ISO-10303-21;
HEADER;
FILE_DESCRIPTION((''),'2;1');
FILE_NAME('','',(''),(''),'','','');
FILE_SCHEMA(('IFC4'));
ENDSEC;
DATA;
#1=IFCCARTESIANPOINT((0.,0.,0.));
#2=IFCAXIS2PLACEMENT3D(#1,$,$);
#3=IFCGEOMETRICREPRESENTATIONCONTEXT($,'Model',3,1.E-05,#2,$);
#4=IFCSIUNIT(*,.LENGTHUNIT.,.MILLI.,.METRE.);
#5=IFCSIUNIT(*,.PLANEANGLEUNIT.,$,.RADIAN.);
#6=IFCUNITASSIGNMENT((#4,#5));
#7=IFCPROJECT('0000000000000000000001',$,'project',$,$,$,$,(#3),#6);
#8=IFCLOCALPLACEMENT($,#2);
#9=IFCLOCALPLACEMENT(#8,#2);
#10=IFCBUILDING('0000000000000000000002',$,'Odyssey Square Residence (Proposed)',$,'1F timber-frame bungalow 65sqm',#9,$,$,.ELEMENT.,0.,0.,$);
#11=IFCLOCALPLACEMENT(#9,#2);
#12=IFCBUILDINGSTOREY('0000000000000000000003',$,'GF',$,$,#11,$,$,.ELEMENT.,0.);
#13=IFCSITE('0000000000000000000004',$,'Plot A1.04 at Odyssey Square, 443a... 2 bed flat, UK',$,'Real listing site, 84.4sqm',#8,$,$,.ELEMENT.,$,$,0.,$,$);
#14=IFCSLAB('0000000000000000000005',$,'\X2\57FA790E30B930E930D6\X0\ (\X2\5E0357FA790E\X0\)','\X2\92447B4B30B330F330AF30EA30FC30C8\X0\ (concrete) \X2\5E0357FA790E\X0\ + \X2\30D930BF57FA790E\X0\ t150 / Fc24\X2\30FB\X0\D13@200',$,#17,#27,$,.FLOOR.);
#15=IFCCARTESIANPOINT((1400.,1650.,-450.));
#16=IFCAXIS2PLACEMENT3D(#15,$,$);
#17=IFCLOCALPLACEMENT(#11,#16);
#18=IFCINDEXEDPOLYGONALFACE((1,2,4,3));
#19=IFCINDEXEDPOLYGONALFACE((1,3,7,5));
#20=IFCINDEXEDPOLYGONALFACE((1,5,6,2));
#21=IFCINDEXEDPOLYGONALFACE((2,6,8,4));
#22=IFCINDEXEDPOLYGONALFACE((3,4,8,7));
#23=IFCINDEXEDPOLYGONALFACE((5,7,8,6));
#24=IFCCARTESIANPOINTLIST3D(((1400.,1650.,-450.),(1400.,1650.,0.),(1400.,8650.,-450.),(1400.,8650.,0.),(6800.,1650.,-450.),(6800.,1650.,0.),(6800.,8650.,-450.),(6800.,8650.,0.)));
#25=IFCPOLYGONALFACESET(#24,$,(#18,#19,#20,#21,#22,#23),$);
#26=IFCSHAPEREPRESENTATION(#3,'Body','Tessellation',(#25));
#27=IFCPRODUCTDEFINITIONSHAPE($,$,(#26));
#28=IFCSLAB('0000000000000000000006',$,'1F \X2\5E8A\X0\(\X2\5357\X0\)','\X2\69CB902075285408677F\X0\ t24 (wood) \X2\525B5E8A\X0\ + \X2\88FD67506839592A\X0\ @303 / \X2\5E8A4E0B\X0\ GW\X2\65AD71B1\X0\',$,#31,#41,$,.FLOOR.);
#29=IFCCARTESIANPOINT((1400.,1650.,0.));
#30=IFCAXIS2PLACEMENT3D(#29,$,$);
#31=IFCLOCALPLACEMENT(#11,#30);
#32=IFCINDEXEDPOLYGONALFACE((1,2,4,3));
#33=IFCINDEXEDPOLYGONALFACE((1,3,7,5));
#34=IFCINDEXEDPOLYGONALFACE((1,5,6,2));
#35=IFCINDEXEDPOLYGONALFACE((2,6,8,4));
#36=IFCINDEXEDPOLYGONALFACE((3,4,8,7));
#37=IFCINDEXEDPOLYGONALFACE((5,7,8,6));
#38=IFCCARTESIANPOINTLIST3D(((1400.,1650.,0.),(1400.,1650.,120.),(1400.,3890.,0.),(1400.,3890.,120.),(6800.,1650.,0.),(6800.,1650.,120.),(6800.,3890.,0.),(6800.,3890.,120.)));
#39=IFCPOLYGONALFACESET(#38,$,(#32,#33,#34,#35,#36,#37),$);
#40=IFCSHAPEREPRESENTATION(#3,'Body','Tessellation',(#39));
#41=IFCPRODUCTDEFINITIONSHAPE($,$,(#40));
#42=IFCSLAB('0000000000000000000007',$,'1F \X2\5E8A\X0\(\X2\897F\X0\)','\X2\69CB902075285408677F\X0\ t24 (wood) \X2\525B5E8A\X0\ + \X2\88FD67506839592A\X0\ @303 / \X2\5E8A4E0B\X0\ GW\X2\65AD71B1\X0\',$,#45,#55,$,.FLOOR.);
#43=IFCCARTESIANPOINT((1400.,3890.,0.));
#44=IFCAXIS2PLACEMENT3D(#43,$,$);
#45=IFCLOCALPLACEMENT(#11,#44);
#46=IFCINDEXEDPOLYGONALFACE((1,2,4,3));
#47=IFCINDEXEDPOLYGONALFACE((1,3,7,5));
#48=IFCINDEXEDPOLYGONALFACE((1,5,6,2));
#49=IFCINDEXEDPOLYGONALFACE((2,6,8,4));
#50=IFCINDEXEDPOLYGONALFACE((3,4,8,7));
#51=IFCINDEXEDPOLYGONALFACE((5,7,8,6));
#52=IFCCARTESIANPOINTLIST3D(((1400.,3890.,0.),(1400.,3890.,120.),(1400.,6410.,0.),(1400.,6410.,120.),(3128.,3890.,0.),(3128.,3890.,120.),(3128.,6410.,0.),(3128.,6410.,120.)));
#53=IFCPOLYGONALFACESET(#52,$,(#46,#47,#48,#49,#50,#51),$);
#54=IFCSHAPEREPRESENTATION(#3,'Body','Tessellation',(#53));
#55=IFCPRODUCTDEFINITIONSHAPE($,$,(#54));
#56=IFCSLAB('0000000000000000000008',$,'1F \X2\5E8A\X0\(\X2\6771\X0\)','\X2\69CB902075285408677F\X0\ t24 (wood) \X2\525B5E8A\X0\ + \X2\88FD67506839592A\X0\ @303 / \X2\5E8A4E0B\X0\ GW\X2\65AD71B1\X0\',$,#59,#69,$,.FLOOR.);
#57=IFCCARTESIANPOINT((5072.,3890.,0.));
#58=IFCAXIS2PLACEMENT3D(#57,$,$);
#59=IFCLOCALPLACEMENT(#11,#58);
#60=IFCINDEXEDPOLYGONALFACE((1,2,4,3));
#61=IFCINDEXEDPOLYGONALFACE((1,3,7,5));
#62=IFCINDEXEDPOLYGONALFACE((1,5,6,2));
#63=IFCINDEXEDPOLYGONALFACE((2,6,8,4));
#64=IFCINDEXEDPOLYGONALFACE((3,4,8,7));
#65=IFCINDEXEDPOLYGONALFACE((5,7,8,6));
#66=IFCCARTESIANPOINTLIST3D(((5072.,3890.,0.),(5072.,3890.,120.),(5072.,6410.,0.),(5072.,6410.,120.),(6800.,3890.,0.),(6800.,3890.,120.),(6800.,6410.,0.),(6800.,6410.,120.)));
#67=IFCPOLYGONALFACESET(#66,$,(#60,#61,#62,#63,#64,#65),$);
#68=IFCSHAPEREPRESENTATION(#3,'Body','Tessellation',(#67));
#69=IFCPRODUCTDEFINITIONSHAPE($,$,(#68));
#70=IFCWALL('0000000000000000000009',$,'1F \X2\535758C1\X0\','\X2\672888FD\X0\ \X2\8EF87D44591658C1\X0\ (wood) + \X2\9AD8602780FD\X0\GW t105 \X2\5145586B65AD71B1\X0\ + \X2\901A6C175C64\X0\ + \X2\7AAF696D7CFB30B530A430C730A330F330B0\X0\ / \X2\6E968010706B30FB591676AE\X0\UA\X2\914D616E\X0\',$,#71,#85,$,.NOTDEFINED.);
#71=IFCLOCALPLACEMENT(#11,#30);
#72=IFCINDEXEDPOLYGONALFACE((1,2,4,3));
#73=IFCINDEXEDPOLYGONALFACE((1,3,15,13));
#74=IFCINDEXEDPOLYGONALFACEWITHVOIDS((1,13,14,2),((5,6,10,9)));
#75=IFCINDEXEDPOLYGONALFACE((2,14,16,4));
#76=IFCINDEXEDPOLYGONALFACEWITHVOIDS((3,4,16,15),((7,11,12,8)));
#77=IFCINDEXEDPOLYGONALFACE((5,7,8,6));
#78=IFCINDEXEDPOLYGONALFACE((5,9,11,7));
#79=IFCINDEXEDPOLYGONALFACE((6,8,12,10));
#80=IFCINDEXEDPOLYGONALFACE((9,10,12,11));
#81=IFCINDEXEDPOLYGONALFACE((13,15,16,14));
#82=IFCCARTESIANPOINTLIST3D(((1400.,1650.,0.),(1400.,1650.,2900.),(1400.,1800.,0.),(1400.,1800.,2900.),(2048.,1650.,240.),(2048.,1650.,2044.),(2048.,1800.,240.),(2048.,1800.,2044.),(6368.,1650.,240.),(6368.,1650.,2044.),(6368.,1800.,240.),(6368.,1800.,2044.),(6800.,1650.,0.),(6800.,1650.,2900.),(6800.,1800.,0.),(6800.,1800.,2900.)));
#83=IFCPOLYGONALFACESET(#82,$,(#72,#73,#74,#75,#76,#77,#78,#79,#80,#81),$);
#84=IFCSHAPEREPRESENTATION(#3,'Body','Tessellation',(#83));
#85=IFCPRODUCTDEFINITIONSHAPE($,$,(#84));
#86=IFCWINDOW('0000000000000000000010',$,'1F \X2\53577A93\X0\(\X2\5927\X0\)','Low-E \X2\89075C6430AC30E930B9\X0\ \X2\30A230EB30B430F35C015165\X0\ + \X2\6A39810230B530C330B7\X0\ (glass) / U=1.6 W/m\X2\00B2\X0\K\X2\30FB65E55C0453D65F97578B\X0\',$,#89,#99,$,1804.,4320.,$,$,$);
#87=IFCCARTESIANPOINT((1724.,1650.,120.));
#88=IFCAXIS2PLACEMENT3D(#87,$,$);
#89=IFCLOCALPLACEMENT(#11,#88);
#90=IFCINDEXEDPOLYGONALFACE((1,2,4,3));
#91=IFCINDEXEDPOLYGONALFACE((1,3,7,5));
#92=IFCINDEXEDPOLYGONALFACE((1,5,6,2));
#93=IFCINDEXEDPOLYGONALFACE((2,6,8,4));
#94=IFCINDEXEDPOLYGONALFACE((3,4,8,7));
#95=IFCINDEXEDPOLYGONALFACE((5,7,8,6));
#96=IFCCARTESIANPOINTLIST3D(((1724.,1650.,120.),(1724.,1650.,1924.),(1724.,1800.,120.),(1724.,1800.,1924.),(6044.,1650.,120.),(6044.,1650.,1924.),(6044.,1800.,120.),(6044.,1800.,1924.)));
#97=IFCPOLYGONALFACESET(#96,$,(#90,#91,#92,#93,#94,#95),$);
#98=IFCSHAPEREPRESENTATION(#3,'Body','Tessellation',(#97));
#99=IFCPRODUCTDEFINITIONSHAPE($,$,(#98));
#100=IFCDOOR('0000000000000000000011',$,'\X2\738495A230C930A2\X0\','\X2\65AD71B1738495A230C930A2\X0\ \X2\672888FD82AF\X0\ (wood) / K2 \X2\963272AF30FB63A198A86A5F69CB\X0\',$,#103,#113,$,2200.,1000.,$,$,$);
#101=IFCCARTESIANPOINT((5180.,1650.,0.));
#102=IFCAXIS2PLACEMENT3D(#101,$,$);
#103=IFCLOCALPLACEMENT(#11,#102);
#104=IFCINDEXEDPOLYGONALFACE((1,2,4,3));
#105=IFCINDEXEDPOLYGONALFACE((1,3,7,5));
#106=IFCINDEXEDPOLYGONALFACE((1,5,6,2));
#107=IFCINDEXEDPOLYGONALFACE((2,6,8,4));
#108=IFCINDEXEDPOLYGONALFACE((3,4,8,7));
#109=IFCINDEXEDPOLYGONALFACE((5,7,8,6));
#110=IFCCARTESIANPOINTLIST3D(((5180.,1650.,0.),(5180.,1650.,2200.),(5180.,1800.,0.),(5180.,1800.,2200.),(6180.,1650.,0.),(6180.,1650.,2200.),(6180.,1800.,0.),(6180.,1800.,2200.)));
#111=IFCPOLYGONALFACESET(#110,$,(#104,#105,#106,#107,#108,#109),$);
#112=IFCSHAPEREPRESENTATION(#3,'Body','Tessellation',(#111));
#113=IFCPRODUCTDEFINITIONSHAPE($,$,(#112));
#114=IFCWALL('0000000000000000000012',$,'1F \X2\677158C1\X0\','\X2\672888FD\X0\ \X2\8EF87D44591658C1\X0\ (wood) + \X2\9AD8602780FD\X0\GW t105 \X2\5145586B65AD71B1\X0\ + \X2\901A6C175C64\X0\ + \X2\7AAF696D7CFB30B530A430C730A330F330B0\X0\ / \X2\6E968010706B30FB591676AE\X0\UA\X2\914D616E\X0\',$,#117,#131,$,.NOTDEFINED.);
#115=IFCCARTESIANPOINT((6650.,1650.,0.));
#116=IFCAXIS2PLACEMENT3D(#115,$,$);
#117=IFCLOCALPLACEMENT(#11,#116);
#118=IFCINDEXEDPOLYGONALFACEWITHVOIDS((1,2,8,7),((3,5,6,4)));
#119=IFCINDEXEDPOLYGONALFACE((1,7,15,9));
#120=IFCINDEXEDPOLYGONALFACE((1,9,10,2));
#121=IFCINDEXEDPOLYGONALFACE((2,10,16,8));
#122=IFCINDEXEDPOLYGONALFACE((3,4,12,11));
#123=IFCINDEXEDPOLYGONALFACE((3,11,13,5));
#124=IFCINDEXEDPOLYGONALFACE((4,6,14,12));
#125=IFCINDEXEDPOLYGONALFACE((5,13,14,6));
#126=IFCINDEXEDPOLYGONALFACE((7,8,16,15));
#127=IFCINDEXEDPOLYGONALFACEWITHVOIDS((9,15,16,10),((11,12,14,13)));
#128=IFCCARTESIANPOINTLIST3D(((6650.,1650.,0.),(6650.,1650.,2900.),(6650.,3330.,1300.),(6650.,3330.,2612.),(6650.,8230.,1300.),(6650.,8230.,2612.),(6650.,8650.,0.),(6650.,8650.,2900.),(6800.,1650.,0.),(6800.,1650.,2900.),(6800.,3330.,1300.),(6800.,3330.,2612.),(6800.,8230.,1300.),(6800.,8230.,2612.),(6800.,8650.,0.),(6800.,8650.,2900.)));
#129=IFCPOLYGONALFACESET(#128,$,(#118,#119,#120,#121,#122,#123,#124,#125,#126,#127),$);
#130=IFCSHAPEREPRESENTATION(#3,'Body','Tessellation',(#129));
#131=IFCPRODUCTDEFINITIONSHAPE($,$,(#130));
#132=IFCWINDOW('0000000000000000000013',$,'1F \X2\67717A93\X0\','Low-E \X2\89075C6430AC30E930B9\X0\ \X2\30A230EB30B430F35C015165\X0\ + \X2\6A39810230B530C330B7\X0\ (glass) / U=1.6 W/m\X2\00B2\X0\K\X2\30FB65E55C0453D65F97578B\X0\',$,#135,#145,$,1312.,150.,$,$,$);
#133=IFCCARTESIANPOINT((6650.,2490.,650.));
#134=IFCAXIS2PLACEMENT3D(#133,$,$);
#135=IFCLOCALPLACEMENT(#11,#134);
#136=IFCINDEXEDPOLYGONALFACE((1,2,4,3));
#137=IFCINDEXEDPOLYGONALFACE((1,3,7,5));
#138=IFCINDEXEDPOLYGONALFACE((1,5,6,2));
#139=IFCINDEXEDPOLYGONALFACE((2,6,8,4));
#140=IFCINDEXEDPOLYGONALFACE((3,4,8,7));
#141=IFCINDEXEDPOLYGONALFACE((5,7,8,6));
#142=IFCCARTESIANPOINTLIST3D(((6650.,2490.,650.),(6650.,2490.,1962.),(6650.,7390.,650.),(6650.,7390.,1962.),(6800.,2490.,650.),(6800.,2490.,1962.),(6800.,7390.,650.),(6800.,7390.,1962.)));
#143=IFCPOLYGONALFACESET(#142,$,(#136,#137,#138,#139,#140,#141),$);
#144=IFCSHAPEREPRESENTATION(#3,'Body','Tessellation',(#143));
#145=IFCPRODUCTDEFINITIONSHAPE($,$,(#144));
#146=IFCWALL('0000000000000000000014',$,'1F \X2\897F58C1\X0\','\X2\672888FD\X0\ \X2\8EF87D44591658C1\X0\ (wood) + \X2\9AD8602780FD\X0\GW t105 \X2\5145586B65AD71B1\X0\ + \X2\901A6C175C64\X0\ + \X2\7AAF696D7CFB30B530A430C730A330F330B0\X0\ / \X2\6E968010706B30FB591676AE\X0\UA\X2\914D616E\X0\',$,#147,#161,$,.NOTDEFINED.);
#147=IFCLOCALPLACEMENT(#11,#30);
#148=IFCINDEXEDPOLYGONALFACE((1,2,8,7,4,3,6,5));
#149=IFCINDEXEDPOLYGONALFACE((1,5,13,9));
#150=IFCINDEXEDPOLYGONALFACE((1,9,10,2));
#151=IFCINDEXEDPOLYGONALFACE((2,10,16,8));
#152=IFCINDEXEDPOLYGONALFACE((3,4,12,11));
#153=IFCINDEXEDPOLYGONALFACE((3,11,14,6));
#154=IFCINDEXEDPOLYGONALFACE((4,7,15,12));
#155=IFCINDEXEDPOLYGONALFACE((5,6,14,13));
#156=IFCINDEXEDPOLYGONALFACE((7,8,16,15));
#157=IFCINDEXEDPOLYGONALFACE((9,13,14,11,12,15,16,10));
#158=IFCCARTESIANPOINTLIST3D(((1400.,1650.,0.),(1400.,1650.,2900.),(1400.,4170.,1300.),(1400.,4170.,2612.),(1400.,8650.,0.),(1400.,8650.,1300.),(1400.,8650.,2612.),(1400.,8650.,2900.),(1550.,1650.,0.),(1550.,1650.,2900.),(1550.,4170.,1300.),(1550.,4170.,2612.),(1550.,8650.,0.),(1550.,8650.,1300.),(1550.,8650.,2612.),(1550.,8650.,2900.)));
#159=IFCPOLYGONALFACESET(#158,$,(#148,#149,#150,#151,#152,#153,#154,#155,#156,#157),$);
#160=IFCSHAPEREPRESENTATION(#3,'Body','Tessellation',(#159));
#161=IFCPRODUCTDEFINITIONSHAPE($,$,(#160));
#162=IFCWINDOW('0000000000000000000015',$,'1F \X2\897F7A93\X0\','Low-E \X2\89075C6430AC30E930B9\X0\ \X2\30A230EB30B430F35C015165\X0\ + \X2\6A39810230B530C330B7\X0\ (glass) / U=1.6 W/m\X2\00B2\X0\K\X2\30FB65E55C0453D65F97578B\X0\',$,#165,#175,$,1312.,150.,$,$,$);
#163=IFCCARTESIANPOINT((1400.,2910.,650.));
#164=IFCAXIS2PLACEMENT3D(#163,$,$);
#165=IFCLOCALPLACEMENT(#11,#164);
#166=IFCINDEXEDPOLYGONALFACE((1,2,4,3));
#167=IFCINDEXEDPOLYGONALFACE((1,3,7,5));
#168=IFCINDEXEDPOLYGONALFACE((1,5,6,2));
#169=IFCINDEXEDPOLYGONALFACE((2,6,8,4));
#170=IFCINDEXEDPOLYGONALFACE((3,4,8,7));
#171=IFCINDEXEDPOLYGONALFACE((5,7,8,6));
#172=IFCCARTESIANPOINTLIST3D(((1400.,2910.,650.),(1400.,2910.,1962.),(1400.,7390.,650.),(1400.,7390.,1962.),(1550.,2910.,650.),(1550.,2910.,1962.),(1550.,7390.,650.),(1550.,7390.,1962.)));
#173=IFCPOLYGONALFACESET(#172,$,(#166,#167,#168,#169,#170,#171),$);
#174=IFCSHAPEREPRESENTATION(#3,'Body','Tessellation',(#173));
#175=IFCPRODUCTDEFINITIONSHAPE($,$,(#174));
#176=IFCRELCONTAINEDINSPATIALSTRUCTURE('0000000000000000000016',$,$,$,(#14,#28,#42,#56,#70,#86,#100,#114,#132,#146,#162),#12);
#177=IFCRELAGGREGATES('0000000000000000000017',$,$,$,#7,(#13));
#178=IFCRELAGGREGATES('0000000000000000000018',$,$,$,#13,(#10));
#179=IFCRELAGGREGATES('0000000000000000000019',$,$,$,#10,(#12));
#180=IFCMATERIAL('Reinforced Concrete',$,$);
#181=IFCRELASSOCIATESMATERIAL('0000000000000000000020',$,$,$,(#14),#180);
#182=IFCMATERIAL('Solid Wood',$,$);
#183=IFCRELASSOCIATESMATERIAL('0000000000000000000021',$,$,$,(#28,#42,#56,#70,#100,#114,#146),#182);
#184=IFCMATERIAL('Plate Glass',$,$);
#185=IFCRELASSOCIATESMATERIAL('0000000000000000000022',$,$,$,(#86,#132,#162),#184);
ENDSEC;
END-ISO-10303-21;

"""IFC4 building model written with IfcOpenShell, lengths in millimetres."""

from ifc_helpers import new_model, si_unit, frame, frame_2d, origin, place, context, project, spatial, rectangle, extrude, material, element, fill, save


model = new_model("IFC4")

# Units and contexts
model_context = context("Model", 3, precision=1e-05, world=origin())
ifc_project = project(units=[si_unit("LENGTHUNIT", "METRE", prefix="MILLI"), si_unit("PLANEANGLEUNIT", "RADIAN")], contexts=[model_context])

# Site, building, storey
site_placement = place(None, origin())
site = spatial("IfcSite", under=ifc_project, at=site_placement, Name="Plot A1.04 at Odyssey Square, 443a... 2 bed flat, UK", ObjectType="Real listing site, 84.4sqm", CompositionType="ELEMENT", RefElevation=0.0)
building_placement = place(site_placement, origin())
building = spatial("IfcBuilding", under=site, at=building_placement, Name="Odyssey Square Residence (Proposed)", ObjectType="1F timber-frame bungalow 65sqm", CompositionType="ELEMENT", ElevationOfRefHeight=0.0, ElevationOfTerrain=0.0)
storey_placement = place(building_placement, origin())
storey = spatial("IfcBuildingStorey", under=building, at=storey_placement, Name="GF", CompositionType="ELEMENT", Elevation=0.0)

# Slabs
ifc_material_1 = material(Name="Reinforced Concrete")
slab_1_placement = place(storey_placement, frame((1400.0, 1650.0, -450.0)))
element("IfcSlab", 1, at=slab_1_placement, inside=storey, material=ifc_material_1, Name="基礎スラブ (布基礎)", Description="鉄筋コンクリート (concrete) 布基礎 + ベタ基礎 t150 / Fc24・D13@200", PredefinedType="FLOOR", context=model_context, shape_type="SweptSolid", body=[
    extrude(rectangle(XDim=5400.0, YDim=7000.0, at=frame_2d((2700.0, 3500.0))), frame((1400.0, 1650.0, -450.0)), (0.0, 0.0, 1.0), 450.0),
])
ifc_material_2 = material(Name="Solid Wood")
slab_2_placement = place(storey_placement, frame((1400.0, 1650.0, 0.0)))
element("IfcSlab", 2, at=slab_2_placement, inside=storey, material=ifc_material_2, Name="1F 床(南)", Description="構造用合板 t24 (wood) 剛床 + 製材根太 @303 / 床下 GW断熱", PredefinedType="FLOOR", context=model_context, shape_type="SweptSolid", body=[
    extrude(rectangle(XDim=5400.0, YDim=2240.0, at=frame_2d((2700.0, 1120.0))), frame((1400.0, 1650.0, 0.0)), (0.0, 0.0, 1.0), 120.0),
])
slab_3_placement = place(storey_placement, frame((1400.0, 3890.0, 0.0)))
element("IfcSlab", 3, at=slab_3_placement, inside=storey, material=ifc_material_2, Name="1F 床(西)", Description="構造用合板 t24 (wood) 剛床 + 製材根太 @303 / 床下 GW断熱", PredefinedType="FLOOR", context=model_context, shape_type="SweptSolid", body=[
    extrude(rectangle(XDim=1728.0, YDim=2520.0, at=frame_2d((864.0, 1260.0))), frame((1400.0, 3890.0, 0.0)), (0.0, 0.0, 1.0), 120.0),
])
slab_4_placement = place(storey_placement, frame((5072.0, 3890.0, 0.0)))
element("IfcSlab", 4, at=slab_4_placement, inside=storey, material=ifc_material_2, Name="1F 床(東)", Description="構造用合板 t24 (wood) 剛床 + 製材根太 @303 / 床下 GW断熱", PredefinedType="FLOOR", context=model_context, shape_type="SweptSolid", body=[
    extrude(rectangle(XDim=1728.0, YDim=2520.0, at=frame_2d((864.0, 1260.0))), frame((5072.0, 3890.0, 0.0)), (0.0, 0.0, 1.0), 120.0),
])

# Wall, openings, window, door
wall_1_placement = place(storey_placement, frame((1400.0, 1650.0, 0.0)))
wall_1 = element("IfcWall", 5, at=wall_1_placement, inside=storey, material=ifc_material_2, Name="1F 南壁", Description="木製 軸組外壁 (wood) + 高性能GW t105 充填断熱 + 通気層 + 窯業系サイディング / 準耐火・外皮UA配慮", PredefinedType="NOTDEFINED", context=model_context, shape_type="SweptSolid", body=[
    extrude(rectangle(XDim=5400.0, YDim=150.0, at=frame_2d((2700.0, 75.0))), frame((1400.0, 1650.0, 0.0)), (0.0, 0.0, 1.0), 2900.0),
])
opening_1_placement = place(storey_placement, frame((1724.0, 1650.0, 120.0)))
opening_1 = element("IfcOpeningElement", 6, at=opening_1_placement, cuts=wall_1, PredefinedType="NOTDEFINED", context=model_context, shape_type="SweptSolid", body=[
    extrude(rectangle(XDim=4320.0, YDim=150.0, at=frame_2d((2160.0, 75.0))), frame((1724.0, 1650.0, 120.0)), (0.0, 0.0, 1.0), 1804.0),
])
opening_2_placement = place(storey_placement, frame((5180.0, 1650.0, 0.0)))
opening_2 = element("IfcOpeningElement", 7, at=opening_2_placement, cuts=wall_1, PredefinedType="NOTDEFINED", context=model_context, shape_type="SweptSolid", body=[
    extrude(rectangle(XDim=1000.0, YDim=150.0, at=frame_2d((500.0, 75.0))), frame((5180.0, 1650.0, 0.0)), (0.0, 0.0, 1.0), 2200.0),
])
ifc_material_3 = material(Name="Plate Glass")
window_1_placement = place(storey_placement, frame((1724.0, 1650.0, 120.0)))
window_1 = element("IfcWindow", 8, at=window_1_placement, inside=storey, material=ifc_material_3, Name="1F 南窓(大)", Description="Low-E 複層ガラス アルゴン封入 + 樹脂サッシ (glass) / U=1.6 W/m²K・日射取得型", OverallHeight=1804.0, OverallWidth=4320.0, context=model_context, shape_type="SweptSolid", body=[
    extrude(rectangle(XDim=4320.0, YDim=150.0, at=frame_2d((2160.0, 75.0))), frame((1724.0, 1650.0, 120.0)), (0.0, 0.0, 1.0), 1804.0),
])
fill(opening_1, window_1)
door_placement = place(storey_placement, frame((5180.0, 1650.0, 0.0)))
door = element("IfcDoor", 9, at=door_placement, inside=storey, material=ifc_material_2, Name="玄関ドア", Description="断熱玄関ドア 木製芯 (wood) / K2 防犯・採風機構", OverallHeight=2200.0, OverallWidth=1000.0, context=model_context, shape_type="SweptSolid", body=[
    extrude(rectangle(XDim=1000.0, YDim=150.0, at=frame_2d((500.0, 75.0))), frame((5180.0, 1650.0, 0.0)), (0.0, 0.0, 1.0), 2200.0),
])
fill(opening_2, door)

# Walls, openings, windows
wall_2_placement = place(storey_placement, frame((6650.0, 1650.0, 0.0)))
wall_2 = element("IfcWall", 10, at=wall_2_placement, inside=storey, material=ifc_material_2, Name="1F 東壁", Description="木製 軸組外壁 (wood) + 高性能GW t105 充填断熱 + 通気層 + 窯業系サイディング / 準耐火・外皮UA配慮", PredefinedType="NOTDEFINED", context=model_context, shape_type="SweptSolid", body=[
    extrude(rectangle(XDim=150.0, YDim=7000.0, at=frame_2d((75.0, 3500.0))), frame((6650.0, 1650.0, 0.0)), (0.0, 0.0, 1.0), 2900.0),
])
opening_3_placement = place(storey_placement, frame((6650.0, 2490.0, 650.0)))
opening_3 = element("IfcOpeningElement", 11, at=opening_3_placement, cuts=wall_2, PredefinedType="NOTDEFINED", context=model_context, shape_type="SweptSolid", body=[
    extrude(rectangle(XDim=150.0, YDim=4900.0, at=frame_2d((75.0, 2450.0))), frame((6650.0, 2490.0, 650.0)), (0.0, 0.0, 1.0), 1312.0),
])
window_2_placement = place(storey_placement, frame((6650.0, 2490.0, 650.0)))
window_2 = element("IfcWindow", 12, at=window_2_placement, inside=storey, material=ifc_material_3, Name="1F 東窓", Description="Low-E 複層ガラス アルゴン封入 + 樹脂サッシ (glass) / U=1.6 W/m²K・日射取得型", OverallHeight=1312.0, OverallWidth=150.0, context=model_context, shape_type="SweptSolid", body=[
    extrude(rectangle(XDim=150.0, YDim=4900.0, at=frame_2d((75.0, 2450.0))), frame((6650.0, 2490.0, 650.0)), (0.0, 0.0, 1.0), 1312.0),
])
fill(opening_3, window_2)
wall_3_placement = place(storey_placement, frame((1400.0, 1650.0, 0.0)))
wall_3 = element("IfcWall", 13, at=wall_3_placement, inside=storey, material=ifc_material_2, Name="1F 西壁", Description="木製 軸組外壁 (wood) + 高性能GW t105 充填断熱 + 通気層 + 窯業系サイディング / 準耐火・外皮UA配慮", PredefinedType="NOTDEFINED", context=model_context, shape_type="SweptSolid", body=[
    extrude(rectangle(XDim=150.0, YDim=7000.0, at=frame_2d((75.0, 3500.0))), frame((1400.0, 1650.0, 0.0)), (0.0, 0.0, 1.0), 2900.0),
])
opening_4_placement = place(storey_placement, frame((1400.0, 2910.0, 650.0)))
opening_4 = element("IfcOpeningElement", 14, at=opening_4_placement, cuts=wall_3, PredefinedType="NOTDEFINED", context=model_context, shape_type="SweptSolid", body=[
    extrude(rectangle(XDim=150.0, YDim=4480.0, at=frame_2d((75.0, 2240.0))), frame((1400.0, 2910.0, 650.0)), (0.0, 0.0, 1.0), 1312.0),
])
window_3_placement = place(storey_placement, frame((1400.0, 2910.0, 650.0)))
window_3 = element("IfcWindow", 15, at=window_3_placement, inside=storey, material=ifc_material_3, Name="1F 西窓", Description="Low-E 複層ガラス アルゴン封入 + 樹脂サッシ (glass) / U=1.6 W/m²K・日射取得型", OverallHeight=1312.0, OverallWidth=150.0, context=model_context, shape_type="SweptSolid", body=[
    extrude(rectangle(XDim=150.0, YDim=4480.0, at=frame_2d((75.0, 2240.0))), frame((1400.0, 2910.0, 650.0)), (0.0, 0.0, 1.0), 1312.0),
])
fill(opening_4, window_3)

save(model, "model.ifc")
